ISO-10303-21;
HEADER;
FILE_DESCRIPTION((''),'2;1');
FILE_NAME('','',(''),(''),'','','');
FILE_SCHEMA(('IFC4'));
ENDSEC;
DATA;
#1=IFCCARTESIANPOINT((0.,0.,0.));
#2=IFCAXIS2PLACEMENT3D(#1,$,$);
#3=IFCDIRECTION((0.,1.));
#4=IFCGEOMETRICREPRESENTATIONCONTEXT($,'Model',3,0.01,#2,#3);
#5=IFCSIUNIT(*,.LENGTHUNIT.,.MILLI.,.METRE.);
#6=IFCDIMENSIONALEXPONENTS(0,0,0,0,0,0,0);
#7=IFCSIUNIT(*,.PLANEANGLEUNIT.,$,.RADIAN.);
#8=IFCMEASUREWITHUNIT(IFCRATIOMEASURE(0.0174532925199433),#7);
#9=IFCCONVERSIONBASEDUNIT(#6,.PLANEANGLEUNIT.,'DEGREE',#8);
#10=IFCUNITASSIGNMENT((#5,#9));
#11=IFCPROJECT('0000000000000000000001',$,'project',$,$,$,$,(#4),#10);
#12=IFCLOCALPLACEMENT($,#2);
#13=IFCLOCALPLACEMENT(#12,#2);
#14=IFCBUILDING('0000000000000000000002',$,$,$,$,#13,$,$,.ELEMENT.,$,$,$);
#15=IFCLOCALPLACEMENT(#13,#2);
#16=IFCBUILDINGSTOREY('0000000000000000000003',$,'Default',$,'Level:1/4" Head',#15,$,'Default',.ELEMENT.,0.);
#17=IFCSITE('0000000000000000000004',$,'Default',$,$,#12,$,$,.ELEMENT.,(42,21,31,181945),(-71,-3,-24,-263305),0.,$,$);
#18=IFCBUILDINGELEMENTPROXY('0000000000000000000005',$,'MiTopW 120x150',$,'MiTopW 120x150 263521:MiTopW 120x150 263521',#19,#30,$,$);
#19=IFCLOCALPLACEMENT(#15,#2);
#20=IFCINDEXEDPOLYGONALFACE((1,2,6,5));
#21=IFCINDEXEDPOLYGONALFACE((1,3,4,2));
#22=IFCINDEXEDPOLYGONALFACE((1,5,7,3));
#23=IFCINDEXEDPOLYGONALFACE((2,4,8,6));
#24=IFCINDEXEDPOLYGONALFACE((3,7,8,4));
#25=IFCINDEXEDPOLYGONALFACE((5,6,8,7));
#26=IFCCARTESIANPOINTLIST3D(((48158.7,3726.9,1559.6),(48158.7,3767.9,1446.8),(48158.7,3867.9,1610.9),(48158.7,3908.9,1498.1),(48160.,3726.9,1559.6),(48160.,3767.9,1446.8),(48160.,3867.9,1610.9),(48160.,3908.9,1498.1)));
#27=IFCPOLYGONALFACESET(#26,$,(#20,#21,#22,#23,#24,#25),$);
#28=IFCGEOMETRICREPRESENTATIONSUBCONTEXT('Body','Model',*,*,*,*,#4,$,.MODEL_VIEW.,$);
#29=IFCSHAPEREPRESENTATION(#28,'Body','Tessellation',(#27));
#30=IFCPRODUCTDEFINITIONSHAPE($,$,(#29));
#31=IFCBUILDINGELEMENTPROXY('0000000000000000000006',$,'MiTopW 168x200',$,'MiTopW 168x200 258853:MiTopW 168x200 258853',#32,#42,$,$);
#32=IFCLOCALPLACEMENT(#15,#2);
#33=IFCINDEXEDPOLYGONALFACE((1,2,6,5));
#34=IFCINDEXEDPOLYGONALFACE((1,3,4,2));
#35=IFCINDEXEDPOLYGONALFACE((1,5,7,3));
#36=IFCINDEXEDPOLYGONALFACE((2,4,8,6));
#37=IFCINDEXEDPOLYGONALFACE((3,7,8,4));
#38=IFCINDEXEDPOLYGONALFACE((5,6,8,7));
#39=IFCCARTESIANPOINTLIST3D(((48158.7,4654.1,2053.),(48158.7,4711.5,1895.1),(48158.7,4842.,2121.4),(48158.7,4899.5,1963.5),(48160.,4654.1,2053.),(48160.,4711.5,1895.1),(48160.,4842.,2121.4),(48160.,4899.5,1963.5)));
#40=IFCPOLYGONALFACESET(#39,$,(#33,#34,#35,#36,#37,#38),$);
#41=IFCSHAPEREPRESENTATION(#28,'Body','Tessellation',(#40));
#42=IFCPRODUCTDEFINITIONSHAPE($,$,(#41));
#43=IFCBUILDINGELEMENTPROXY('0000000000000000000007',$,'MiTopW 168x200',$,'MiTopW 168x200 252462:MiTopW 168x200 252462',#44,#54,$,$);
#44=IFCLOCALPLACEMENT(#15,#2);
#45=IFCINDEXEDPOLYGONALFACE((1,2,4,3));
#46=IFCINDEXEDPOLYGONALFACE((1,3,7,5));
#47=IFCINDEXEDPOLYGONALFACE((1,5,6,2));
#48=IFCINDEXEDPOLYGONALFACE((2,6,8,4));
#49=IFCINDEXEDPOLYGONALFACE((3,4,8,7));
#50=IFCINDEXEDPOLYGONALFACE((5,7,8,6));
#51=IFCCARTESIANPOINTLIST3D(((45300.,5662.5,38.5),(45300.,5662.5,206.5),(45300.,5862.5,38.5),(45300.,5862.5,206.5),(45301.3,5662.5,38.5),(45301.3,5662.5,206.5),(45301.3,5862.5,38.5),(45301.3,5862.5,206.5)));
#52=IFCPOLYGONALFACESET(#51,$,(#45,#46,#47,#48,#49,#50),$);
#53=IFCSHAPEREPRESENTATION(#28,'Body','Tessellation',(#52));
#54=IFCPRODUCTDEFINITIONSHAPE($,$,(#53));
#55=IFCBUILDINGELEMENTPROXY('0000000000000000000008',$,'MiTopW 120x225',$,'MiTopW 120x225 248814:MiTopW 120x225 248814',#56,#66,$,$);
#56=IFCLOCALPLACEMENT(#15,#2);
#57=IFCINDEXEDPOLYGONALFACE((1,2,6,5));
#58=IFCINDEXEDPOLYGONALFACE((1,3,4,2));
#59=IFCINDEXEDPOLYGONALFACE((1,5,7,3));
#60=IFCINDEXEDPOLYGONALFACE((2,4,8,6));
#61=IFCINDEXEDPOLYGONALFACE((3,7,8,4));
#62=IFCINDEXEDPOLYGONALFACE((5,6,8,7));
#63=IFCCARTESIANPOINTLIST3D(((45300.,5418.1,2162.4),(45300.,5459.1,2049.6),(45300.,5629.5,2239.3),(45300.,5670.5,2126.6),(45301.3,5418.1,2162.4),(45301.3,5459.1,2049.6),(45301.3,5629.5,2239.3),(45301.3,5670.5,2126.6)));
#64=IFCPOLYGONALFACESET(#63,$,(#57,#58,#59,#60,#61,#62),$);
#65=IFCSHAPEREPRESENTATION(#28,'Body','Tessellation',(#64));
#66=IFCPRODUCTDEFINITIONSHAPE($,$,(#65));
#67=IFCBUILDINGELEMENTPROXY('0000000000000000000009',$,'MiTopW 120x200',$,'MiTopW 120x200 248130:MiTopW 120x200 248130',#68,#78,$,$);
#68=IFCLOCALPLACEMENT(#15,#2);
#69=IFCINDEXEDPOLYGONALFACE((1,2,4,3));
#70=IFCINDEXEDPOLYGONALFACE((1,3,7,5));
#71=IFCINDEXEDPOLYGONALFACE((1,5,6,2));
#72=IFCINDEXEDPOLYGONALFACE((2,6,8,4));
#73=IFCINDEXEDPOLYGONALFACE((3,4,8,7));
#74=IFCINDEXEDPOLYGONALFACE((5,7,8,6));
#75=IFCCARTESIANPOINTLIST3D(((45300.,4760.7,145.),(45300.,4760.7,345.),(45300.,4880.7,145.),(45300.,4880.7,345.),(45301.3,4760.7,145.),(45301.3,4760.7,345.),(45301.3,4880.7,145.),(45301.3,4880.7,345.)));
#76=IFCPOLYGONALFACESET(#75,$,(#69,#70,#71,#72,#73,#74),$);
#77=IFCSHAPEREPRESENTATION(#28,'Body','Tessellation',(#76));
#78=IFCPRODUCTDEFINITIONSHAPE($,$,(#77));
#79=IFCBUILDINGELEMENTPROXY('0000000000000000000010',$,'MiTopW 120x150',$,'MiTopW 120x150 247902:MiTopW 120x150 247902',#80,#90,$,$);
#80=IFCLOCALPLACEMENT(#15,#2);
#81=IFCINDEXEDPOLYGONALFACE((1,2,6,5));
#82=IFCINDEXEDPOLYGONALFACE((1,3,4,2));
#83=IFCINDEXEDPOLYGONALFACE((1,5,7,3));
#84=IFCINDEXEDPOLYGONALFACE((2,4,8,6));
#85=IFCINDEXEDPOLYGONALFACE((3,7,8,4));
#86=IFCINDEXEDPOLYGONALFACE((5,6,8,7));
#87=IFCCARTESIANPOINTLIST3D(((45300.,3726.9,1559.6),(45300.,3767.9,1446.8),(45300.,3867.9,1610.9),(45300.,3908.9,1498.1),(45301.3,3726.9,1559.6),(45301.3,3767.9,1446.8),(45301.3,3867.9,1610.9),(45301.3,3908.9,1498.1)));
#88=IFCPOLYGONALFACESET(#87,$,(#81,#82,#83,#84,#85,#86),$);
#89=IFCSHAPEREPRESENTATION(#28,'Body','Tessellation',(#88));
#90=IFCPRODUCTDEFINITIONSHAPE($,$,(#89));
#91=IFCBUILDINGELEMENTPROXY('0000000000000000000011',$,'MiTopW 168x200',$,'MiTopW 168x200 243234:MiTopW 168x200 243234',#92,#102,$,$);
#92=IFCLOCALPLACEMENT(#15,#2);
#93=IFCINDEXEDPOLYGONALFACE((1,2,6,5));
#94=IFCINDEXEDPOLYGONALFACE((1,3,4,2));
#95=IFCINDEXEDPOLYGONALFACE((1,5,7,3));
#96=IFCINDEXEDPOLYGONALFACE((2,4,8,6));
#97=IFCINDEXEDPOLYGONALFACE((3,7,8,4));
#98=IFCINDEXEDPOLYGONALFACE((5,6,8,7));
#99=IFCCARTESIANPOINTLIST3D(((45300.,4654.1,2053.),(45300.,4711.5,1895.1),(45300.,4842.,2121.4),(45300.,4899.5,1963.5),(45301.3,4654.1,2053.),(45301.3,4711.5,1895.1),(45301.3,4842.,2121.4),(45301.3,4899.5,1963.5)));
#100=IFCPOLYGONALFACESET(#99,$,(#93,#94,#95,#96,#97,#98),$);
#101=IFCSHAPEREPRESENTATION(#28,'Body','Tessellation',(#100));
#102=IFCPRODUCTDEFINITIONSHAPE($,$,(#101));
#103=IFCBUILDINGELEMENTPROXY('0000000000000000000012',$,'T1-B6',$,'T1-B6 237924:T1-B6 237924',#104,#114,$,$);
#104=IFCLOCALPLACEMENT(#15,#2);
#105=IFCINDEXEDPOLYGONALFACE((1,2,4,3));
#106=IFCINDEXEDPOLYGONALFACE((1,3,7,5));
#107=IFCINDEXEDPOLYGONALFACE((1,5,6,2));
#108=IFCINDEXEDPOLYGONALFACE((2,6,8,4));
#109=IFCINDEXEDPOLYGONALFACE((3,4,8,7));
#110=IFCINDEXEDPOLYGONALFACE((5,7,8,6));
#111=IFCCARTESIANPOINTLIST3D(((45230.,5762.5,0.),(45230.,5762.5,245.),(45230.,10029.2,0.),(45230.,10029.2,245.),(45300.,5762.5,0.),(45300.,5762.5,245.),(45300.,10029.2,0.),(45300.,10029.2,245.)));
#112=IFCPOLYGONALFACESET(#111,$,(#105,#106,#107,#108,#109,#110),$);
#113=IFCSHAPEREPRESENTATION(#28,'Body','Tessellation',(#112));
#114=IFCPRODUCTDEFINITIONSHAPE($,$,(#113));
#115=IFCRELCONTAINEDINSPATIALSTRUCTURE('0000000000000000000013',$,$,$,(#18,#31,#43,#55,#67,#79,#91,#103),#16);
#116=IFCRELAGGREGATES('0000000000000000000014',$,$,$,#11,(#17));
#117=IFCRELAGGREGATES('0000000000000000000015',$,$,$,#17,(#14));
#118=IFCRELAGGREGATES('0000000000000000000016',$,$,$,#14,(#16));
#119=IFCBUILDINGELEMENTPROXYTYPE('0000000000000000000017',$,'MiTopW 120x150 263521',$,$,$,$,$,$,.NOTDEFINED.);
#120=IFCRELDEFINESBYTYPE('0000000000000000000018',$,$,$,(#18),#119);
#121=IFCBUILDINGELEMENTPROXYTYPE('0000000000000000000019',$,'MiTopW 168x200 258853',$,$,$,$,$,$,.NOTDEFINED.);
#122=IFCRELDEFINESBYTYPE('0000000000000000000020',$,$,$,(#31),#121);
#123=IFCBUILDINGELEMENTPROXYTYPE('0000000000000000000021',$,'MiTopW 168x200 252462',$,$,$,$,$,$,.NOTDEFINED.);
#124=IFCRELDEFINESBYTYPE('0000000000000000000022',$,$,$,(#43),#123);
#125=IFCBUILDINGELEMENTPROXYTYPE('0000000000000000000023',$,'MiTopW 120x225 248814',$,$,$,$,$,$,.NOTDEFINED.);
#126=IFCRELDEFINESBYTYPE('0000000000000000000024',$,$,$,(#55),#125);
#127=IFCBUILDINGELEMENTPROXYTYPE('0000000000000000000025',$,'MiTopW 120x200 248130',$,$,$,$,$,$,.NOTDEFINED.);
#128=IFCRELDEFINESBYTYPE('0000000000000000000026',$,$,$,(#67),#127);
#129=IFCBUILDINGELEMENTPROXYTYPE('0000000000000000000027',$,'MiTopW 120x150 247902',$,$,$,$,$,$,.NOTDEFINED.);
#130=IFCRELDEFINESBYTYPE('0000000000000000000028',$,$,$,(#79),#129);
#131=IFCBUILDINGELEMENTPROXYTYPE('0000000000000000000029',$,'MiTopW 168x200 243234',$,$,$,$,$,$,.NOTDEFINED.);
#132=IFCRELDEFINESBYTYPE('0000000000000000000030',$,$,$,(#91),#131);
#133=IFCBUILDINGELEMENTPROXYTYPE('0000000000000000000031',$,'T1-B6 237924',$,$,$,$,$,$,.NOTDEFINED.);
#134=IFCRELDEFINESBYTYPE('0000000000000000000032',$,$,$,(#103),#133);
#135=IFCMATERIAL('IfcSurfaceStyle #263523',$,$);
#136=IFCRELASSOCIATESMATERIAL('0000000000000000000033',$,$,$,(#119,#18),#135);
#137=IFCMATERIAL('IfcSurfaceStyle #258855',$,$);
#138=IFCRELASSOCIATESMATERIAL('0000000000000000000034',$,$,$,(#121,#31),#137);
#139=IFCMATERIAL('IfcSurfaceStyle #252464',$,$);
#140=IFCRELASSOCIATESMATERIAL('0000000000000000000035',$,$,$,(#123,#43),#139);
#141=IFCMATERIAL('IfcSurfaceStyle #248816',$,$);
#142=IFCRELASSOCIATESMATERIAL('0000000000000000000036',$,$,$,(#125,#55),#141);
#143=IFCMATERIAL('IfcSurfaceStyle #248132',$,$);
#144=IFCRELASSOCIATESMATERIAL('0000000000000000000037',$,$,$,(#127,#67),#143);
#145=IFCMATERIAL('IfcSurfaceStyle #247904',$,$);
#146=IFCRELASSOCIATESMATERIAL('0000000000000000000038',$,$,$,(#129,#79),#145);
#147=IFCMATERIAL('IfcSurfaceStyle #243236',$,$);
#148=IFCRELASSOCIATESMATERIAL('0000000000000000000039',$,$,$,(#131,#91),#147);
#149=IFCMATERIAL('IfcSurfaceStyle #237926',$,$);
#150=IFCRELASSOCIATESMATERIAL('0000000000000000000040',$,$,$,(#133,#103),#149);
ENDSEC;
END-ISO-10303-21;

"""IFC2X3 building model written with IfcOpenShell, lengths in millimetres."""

from ifc_helpers import new_model, entity, si_unit, converted_unit, direction, frame, origin, origin_2d_with_axis, place, context, subcontext, project, spatial, polyline, rectangle, outline, extrude, source, transform, mapped, material, type_object, type_shapes, element, save


model = new_model("IFC2X3")

# Units and contexts
model_context = context("Model", 3, precision=0.01, world=origin(), true_north=direction((0.0, 1.0)))
body_context = subcontext(model_context, "Body", "Model", "MODEL_VIEW")
ifc_project = project(units=[si_unit("LENGTHUNIT", "METRE", prefix="MILLI"), converted_unit("PLANEANGLEUNIT", "DEGREE", entity("IfcRatioMeasure", 0.0174532925199433), si_unit("PLANEANGLEUNIT", "RADIAN"), dimensions=[0, 0, 0, 0, 0, 0, 0])], contexts=[model_context])

# Site, building, storey
site_placement = place(None, origin())
site = spatial("IfcSite", under=ifc_project, at=site_placement, Name="Default", CompositionType="ELEMENT", RefLatitude=(42, 21, 31, 181945), RefLongitude=(-71, -3, -24, -263305), RefElevation=0.0)
building_placement = place(site_placement, origin())
building = spatial("IfcBuilding", under=site, at=building_placement, CompositionType="ELEMENT")
storey_placement = place(building_placement, origin())
storey = spatial("IfcBuildingStorey", under=building, at=storey_placement, Name="Default", ObjectType="Level:1/4\" Head", LongName="Default", CompositionType="ELEMENT", Elevation=0.0)

# Building element proxies
ifc_material_1 = material(Name="IfcSurfaceStyle #263523")
building_element_proxy_type_1 = type_object("IfcBuildingElementProxyType", Name="MiTopW 120x150 263521", PredefinedType="NOTDEFINED", material=ifc_material_1)
shared_shape_1 = source(origin(), body_context, "Body", "SweptSolid", [
    extrude(outline(polyline([(-75.0, -60.0), (75.0, -60.0), (75.0, 60.0), (-75.0, 60.0), (-75.0, -60.0)])), frame((75.0, 60.0, 0.0), z_axis=(0.0, 0.0, 1.0), x_axis=(-1.0, 0.0, 0.0)), (0.0, 0.0, 1.0), 1.3),
])
type_shapes(building_element_proxy_type_1, [shared_shape_1])
proxy_1_placement = place(building_placement, frame((48160.0, 3726.9, 1559.6), z_axis=(-1.0, 0.0, 0.0), x_axis=(0.0, 0.939693, 0.34202)))
element("IfcBuildingElementProxy", 1, at=proxy_1_placement, inside=storey, type_object=building_element_proxy_type_1, material=ifc_material_1, Name="MiTopW 120x150", ObjectType="MiTopW 120x150 263521:MiTopW 120x150 263521", context=body_context, shape_type="MappedRepresentation", body=[
    mapped(shared_shape_1, transform((0.0, 0.0, 0.0), scale=1.0)),
])
ifc_material_2 = material(Name="IfcSurfaceStyle #258855")
building_element_proxy_type_2 = type_object("IfcBuildingElementProxyType", Name="MiTopW 168x200 258853", PredefinedType="NOTDEFINED", material=ifc_material_2)
shared_shape_2 = source(origin(), body_context, "Body", "SweptSolid", [
    extrude(outline(polyline([(-100.0, -84.0), (100.0, -84.0), (100.0, 84.0), (-100.0, 84.0), (-100.0, -84.0)])), frame((100.0, 84.0, 0.0), z_axis=(0.0, 0.0, 1.0), x_axis=(-1.0, 0.0, 0.0)), (0.0, 0.0, 1.0), 1.3),
])
type_shapes(building_element_proxy_type_2, [shared_shape_2])
proxy_2_placement = place(building_placement, frame((48160.0, 4654.1, 2053.0), z_axis=(-1.0, 0.0, 0.0), x_axis=(0.0, 0.939693, 0.34202)))
element("IfcBuildingElementProxy", 2, at=proxy_2_placement, inside=storey, type_object=building_element_proxy_type_2, material=ifc_material_2, Name="MiTopW 168x200", ObjectType="MiTopW 168x200 258853:MiTopW 168x200 258853", context=body_context, shape_type="MappedRepresentation", body=[
    mapped(shared_shape_2, transform((0.0, 0.0, 0.0), scale=1.0)),
])
ifc_material_3 = material(Name="IfcSurfaceStyle #252464")
building_element_proxy_type_3 = type_object("IfcBuildingElementProxyType", Name="MiTopW 168x200 252462", PredefinedType="NOTDEFINED", material=ifc_material_3)
shared_shape_3 = source(origin(), body_context, "Body", "SweptSolid", [
    extrude(rectangle(XDim=200.0, YDim=168.0, at=origin_2d_with_axis()), frame((100.0, 84.0, 0.0), z_axis=(0.0, 0.0, 1.0), x_axis=(-1.0, 0.0, 0.0)), (0.0, 0.0, 1.0), 1.3),
])
type_shapes(building_element_proxy_type_3, [shared_shape_3])
proxy_3_placement = place(building_placement, frame((45301.3, 5662.5, 206.5), z_axis=(-1.0, 0.0, 0.0), x_axis=(0.0, 1.0, 0.0)))
element("IfcBuildingElementProxy", 3, at=proxy_3_placement, inside=storey, type_object=building_element_proxy_type_3, material=ifc_material_3, Name="MiTopW 168x200", ObjectType="MiTopW 168x200 252462:MiTopW 168x200 252462", context=body_context, shape_type="MappedRepresentation", body=[
    mapped(shared_shape_3, transform((0.0, 0.0, 0.0), scale=1.0)),
])
ifc_material_4 = material(Name="IfcSurfaceStyle #248816")
building_element_proxy_type_4 = type_object("IfcBuildingElementProxyType", Name="MiTopW 120x225 248814", PredefinedType="NOTDEFINED", material=ifc_material_4)
shared_shape_4 = source(origin(), body_context, "Body", "SweptSolid", [
    extrude(outline(polyline([(-112.5, -60.0), (112.5, -60.0), (112.5, 60.0), (-112.5, 60.0), (-112.5, -60.0)])), frame((112.5, 60.0, 0.0), z_axis=(0.0, 0.0, 1.0), x_axis=(-1.0, 0.0, 0.0)), (0.0, 0.0, 1.0), 1.3),
])
type_shapes(building_element_proxy_type_4, [shared_shape_4])
proxy_4_placement = place(building_placement, frame((45301.3, 5418.1, 2162.4), z_axis=(-1.0, 0.0, 0.0), x_axis=(0.0, 0.939693, 0.34202)))
element("IfcBuildingElementProxy", 4, at=proxy_4_placement, inside=storey, type_object=building_element_proxy_type_4, material=ifc_material_4, Name="MiTopW 120x225", ObjectType="MiTopW 120x225 248814:MiTopW 120x225 248814", context=body_context, shape_type="MappedRepresentation", body=[
    mapped(shared_shape_4, transform((0.0, 0.0, 0.0), scale=1.0)),
])
ifc_material_5 = material(Name="IfcSurfaceStyle #248132")
building_element_proxy_type_5 = type_object("IfcBuildingElementProxyType", Name="MiTopW 120x200 248130", PredefinedType="NOTDEFINED", material=ifc_material_5)
shared_shape_5 = source(origin(), body_context, "Body", "SweptSolid", [
    extrude(rectangle(XDim=200.0, YDim=120.0, at=origin_2d_with_axis()), frame((100.0, 60.0, 0.0), z_axis=(0.0, 0.0, 1.0), x_axis=(-1.0, 0.0, 0.0)), (0.0, 0.0, 1.0), 1.3),
])
type_shapes(building_element_proxy_type_5, [shared_shape_5])
proxy_5_placement = place(building_placement, frame((45301.3, 4760.7, 145.0), z_axis=(-1.0, 0.0, 0.0), x_axis=(0.0, 0.0, 1.0)))
element("IfcBuildingElementProxy", 5, at=proxy_5_placement, inside=storey, type_object=building_element_proxy_type_5, material=ifc_material_5, Name="MiTopW 120x200", ObjectType="MiTopW 120x200 248130:MiTopW 120x200 248130", context=body_context, shape_type="MappedRepresentation", body=[
    mapped(shared_shape_5, transform((0.0, 0.0, 0.0), scale=1.0)),
])
ifc_material_6 = material(Name="IfcSurfaceStyle #247904")
building_element_proxy_type_6 = type_object("IfcBuildingElementProxyType", Name="MiTopW 120x150 247902", PredefinedType="NOTDEFINED", material=ifc_material_6)
shared_shape_6 = source(origin(), body_context, "Body", "SweptSolid", [
    extrude(outline(polyline([(-75.0, -60.0), (75.0, -60.0), (75.0, 60.0), (-75.0, 60.0), (-75.0, -60.0)])), frame((75.0, 60.0, 0.0), z_axis=(0.0, 0.0, 1.0), x_axis=(-1.0, 0.0, 0.0)), (0.0, 0.0, 1.0), 1.3),
])
type_shapes(building_element_proxy_type_6, [shared_shape_6])
proxy_6_placement = place(building_placement, frame((45301.3, 3726.9, 1559.6), z_axis=(-1.0, 0.0, 0.0), x_axis=(0.0, 0.939693, 0.34202)))
element("IfcBuildingElementProxy", 6, at=proxy_6_placement, inside=storey, type_object=building_element_proxy_type_6, material=ifc_material_6, Name="MiTopW 120x150", ObjectType="MiTopW 120x150 247902:MiTopW 120x150 247902", context=body_context, shape_type="MappedRepresentation", body=[
    mapped(shared_shape_6, transform((0.0, 0.0, 0.0), scale=1.0)),
])
ifc_material_7 = material(Name="IfcSurfaceStyle #243236")
building_element_proxy_type_7 = type_object("IfcBuildingElementProxyType", Name="MiTopW 168x200 243234", PredefinedType="NOTDEFINED", material=ifc_material_7)
shared_shape_7 = source(origin(), body_context, "Body", "SweptSolid", [
    extrude(outline(polyline([(-100.0, -84.0), (100.0, -84.0), (100.0, 84.0), (-100.0, 84.0), (-100.0, -84.0)])), frame((100.0, 84.0, 0.0), z_axis=(0.0, 0.0, 1.0), x_axis=(-1.0, 0.0, 0.0)), (0.0, 0.0, 1.0), 1.3),
])
type_shapes(building_element_proxy_type_7, [shared_shape_7])
proxy_7_placement = place(building_placement, frame((45301.3, 4654.1, 2053.0), z_axis=(-1.0, 0.0, 0.0), x_axis=(0.0, 0.939693, 0.34202)))
element("IfcBuildingElementProxy", 7, at=proxy_7_placement, inside=storey, type_object=building_element_proxy_type_7, material=ifc_material_7, Name="MiTopW 168x200", ObjectType="MiTopW 168x200 243234:MiTopW 168x200 243234", context=body_context, shape_type="MappedRepresentation", body=[
    mapped(shared_shape_7, transform((0.0, 0.0, 0.0), scale=1.0)),
])
ifc_material_8 = material(Name="IfcSurfaceStyle #237926")
building_element_proxy_type_8 = type_object("IfcBuildingElementProxyType", Name="T1-B6 237924", PredefinedType="NOTDEFINED", material=ifc_material_8)
shared_shape_8 = source(origin(), body_context, "Body", "SweptSolid", [
    extrude(rectangle(XDim=4266.8, YDim=245.0, at=origin_2d_with_axis()), frame((2133.4, 122.5, 0.0), z_axis=(0.0, 0.0, 1.0), x_axis=(-1.0, 0.0, 0.0)), (0.0, 0.0, 1.0), 70.0),
])
type_shapes(building_element_proxy_type_8, [shared_shape_8])
proxy_8_placement = place(building_placement, frame((45300.0, 5762.5, 245.0), z_axis=(-1.0, 0.0, 0.0), x_axis=(0.0, 1.0, 0.0)))
element("IfcBuildingElementProxy", 8, at=proxy_8_placement, inside=storey, type_object=building_element_proxy_type_8, material=ifc_material_8, Name="T1-B6", ObjectType="T1-B6 237924:T1-B6 237924", context=body_context, shape_type="MappedRepresentation", body=[
    mapped(shared_shape_8, transform((0.0, 0.0, 0.0), scale=1.0)),
])

save(model, "model.ifc")
